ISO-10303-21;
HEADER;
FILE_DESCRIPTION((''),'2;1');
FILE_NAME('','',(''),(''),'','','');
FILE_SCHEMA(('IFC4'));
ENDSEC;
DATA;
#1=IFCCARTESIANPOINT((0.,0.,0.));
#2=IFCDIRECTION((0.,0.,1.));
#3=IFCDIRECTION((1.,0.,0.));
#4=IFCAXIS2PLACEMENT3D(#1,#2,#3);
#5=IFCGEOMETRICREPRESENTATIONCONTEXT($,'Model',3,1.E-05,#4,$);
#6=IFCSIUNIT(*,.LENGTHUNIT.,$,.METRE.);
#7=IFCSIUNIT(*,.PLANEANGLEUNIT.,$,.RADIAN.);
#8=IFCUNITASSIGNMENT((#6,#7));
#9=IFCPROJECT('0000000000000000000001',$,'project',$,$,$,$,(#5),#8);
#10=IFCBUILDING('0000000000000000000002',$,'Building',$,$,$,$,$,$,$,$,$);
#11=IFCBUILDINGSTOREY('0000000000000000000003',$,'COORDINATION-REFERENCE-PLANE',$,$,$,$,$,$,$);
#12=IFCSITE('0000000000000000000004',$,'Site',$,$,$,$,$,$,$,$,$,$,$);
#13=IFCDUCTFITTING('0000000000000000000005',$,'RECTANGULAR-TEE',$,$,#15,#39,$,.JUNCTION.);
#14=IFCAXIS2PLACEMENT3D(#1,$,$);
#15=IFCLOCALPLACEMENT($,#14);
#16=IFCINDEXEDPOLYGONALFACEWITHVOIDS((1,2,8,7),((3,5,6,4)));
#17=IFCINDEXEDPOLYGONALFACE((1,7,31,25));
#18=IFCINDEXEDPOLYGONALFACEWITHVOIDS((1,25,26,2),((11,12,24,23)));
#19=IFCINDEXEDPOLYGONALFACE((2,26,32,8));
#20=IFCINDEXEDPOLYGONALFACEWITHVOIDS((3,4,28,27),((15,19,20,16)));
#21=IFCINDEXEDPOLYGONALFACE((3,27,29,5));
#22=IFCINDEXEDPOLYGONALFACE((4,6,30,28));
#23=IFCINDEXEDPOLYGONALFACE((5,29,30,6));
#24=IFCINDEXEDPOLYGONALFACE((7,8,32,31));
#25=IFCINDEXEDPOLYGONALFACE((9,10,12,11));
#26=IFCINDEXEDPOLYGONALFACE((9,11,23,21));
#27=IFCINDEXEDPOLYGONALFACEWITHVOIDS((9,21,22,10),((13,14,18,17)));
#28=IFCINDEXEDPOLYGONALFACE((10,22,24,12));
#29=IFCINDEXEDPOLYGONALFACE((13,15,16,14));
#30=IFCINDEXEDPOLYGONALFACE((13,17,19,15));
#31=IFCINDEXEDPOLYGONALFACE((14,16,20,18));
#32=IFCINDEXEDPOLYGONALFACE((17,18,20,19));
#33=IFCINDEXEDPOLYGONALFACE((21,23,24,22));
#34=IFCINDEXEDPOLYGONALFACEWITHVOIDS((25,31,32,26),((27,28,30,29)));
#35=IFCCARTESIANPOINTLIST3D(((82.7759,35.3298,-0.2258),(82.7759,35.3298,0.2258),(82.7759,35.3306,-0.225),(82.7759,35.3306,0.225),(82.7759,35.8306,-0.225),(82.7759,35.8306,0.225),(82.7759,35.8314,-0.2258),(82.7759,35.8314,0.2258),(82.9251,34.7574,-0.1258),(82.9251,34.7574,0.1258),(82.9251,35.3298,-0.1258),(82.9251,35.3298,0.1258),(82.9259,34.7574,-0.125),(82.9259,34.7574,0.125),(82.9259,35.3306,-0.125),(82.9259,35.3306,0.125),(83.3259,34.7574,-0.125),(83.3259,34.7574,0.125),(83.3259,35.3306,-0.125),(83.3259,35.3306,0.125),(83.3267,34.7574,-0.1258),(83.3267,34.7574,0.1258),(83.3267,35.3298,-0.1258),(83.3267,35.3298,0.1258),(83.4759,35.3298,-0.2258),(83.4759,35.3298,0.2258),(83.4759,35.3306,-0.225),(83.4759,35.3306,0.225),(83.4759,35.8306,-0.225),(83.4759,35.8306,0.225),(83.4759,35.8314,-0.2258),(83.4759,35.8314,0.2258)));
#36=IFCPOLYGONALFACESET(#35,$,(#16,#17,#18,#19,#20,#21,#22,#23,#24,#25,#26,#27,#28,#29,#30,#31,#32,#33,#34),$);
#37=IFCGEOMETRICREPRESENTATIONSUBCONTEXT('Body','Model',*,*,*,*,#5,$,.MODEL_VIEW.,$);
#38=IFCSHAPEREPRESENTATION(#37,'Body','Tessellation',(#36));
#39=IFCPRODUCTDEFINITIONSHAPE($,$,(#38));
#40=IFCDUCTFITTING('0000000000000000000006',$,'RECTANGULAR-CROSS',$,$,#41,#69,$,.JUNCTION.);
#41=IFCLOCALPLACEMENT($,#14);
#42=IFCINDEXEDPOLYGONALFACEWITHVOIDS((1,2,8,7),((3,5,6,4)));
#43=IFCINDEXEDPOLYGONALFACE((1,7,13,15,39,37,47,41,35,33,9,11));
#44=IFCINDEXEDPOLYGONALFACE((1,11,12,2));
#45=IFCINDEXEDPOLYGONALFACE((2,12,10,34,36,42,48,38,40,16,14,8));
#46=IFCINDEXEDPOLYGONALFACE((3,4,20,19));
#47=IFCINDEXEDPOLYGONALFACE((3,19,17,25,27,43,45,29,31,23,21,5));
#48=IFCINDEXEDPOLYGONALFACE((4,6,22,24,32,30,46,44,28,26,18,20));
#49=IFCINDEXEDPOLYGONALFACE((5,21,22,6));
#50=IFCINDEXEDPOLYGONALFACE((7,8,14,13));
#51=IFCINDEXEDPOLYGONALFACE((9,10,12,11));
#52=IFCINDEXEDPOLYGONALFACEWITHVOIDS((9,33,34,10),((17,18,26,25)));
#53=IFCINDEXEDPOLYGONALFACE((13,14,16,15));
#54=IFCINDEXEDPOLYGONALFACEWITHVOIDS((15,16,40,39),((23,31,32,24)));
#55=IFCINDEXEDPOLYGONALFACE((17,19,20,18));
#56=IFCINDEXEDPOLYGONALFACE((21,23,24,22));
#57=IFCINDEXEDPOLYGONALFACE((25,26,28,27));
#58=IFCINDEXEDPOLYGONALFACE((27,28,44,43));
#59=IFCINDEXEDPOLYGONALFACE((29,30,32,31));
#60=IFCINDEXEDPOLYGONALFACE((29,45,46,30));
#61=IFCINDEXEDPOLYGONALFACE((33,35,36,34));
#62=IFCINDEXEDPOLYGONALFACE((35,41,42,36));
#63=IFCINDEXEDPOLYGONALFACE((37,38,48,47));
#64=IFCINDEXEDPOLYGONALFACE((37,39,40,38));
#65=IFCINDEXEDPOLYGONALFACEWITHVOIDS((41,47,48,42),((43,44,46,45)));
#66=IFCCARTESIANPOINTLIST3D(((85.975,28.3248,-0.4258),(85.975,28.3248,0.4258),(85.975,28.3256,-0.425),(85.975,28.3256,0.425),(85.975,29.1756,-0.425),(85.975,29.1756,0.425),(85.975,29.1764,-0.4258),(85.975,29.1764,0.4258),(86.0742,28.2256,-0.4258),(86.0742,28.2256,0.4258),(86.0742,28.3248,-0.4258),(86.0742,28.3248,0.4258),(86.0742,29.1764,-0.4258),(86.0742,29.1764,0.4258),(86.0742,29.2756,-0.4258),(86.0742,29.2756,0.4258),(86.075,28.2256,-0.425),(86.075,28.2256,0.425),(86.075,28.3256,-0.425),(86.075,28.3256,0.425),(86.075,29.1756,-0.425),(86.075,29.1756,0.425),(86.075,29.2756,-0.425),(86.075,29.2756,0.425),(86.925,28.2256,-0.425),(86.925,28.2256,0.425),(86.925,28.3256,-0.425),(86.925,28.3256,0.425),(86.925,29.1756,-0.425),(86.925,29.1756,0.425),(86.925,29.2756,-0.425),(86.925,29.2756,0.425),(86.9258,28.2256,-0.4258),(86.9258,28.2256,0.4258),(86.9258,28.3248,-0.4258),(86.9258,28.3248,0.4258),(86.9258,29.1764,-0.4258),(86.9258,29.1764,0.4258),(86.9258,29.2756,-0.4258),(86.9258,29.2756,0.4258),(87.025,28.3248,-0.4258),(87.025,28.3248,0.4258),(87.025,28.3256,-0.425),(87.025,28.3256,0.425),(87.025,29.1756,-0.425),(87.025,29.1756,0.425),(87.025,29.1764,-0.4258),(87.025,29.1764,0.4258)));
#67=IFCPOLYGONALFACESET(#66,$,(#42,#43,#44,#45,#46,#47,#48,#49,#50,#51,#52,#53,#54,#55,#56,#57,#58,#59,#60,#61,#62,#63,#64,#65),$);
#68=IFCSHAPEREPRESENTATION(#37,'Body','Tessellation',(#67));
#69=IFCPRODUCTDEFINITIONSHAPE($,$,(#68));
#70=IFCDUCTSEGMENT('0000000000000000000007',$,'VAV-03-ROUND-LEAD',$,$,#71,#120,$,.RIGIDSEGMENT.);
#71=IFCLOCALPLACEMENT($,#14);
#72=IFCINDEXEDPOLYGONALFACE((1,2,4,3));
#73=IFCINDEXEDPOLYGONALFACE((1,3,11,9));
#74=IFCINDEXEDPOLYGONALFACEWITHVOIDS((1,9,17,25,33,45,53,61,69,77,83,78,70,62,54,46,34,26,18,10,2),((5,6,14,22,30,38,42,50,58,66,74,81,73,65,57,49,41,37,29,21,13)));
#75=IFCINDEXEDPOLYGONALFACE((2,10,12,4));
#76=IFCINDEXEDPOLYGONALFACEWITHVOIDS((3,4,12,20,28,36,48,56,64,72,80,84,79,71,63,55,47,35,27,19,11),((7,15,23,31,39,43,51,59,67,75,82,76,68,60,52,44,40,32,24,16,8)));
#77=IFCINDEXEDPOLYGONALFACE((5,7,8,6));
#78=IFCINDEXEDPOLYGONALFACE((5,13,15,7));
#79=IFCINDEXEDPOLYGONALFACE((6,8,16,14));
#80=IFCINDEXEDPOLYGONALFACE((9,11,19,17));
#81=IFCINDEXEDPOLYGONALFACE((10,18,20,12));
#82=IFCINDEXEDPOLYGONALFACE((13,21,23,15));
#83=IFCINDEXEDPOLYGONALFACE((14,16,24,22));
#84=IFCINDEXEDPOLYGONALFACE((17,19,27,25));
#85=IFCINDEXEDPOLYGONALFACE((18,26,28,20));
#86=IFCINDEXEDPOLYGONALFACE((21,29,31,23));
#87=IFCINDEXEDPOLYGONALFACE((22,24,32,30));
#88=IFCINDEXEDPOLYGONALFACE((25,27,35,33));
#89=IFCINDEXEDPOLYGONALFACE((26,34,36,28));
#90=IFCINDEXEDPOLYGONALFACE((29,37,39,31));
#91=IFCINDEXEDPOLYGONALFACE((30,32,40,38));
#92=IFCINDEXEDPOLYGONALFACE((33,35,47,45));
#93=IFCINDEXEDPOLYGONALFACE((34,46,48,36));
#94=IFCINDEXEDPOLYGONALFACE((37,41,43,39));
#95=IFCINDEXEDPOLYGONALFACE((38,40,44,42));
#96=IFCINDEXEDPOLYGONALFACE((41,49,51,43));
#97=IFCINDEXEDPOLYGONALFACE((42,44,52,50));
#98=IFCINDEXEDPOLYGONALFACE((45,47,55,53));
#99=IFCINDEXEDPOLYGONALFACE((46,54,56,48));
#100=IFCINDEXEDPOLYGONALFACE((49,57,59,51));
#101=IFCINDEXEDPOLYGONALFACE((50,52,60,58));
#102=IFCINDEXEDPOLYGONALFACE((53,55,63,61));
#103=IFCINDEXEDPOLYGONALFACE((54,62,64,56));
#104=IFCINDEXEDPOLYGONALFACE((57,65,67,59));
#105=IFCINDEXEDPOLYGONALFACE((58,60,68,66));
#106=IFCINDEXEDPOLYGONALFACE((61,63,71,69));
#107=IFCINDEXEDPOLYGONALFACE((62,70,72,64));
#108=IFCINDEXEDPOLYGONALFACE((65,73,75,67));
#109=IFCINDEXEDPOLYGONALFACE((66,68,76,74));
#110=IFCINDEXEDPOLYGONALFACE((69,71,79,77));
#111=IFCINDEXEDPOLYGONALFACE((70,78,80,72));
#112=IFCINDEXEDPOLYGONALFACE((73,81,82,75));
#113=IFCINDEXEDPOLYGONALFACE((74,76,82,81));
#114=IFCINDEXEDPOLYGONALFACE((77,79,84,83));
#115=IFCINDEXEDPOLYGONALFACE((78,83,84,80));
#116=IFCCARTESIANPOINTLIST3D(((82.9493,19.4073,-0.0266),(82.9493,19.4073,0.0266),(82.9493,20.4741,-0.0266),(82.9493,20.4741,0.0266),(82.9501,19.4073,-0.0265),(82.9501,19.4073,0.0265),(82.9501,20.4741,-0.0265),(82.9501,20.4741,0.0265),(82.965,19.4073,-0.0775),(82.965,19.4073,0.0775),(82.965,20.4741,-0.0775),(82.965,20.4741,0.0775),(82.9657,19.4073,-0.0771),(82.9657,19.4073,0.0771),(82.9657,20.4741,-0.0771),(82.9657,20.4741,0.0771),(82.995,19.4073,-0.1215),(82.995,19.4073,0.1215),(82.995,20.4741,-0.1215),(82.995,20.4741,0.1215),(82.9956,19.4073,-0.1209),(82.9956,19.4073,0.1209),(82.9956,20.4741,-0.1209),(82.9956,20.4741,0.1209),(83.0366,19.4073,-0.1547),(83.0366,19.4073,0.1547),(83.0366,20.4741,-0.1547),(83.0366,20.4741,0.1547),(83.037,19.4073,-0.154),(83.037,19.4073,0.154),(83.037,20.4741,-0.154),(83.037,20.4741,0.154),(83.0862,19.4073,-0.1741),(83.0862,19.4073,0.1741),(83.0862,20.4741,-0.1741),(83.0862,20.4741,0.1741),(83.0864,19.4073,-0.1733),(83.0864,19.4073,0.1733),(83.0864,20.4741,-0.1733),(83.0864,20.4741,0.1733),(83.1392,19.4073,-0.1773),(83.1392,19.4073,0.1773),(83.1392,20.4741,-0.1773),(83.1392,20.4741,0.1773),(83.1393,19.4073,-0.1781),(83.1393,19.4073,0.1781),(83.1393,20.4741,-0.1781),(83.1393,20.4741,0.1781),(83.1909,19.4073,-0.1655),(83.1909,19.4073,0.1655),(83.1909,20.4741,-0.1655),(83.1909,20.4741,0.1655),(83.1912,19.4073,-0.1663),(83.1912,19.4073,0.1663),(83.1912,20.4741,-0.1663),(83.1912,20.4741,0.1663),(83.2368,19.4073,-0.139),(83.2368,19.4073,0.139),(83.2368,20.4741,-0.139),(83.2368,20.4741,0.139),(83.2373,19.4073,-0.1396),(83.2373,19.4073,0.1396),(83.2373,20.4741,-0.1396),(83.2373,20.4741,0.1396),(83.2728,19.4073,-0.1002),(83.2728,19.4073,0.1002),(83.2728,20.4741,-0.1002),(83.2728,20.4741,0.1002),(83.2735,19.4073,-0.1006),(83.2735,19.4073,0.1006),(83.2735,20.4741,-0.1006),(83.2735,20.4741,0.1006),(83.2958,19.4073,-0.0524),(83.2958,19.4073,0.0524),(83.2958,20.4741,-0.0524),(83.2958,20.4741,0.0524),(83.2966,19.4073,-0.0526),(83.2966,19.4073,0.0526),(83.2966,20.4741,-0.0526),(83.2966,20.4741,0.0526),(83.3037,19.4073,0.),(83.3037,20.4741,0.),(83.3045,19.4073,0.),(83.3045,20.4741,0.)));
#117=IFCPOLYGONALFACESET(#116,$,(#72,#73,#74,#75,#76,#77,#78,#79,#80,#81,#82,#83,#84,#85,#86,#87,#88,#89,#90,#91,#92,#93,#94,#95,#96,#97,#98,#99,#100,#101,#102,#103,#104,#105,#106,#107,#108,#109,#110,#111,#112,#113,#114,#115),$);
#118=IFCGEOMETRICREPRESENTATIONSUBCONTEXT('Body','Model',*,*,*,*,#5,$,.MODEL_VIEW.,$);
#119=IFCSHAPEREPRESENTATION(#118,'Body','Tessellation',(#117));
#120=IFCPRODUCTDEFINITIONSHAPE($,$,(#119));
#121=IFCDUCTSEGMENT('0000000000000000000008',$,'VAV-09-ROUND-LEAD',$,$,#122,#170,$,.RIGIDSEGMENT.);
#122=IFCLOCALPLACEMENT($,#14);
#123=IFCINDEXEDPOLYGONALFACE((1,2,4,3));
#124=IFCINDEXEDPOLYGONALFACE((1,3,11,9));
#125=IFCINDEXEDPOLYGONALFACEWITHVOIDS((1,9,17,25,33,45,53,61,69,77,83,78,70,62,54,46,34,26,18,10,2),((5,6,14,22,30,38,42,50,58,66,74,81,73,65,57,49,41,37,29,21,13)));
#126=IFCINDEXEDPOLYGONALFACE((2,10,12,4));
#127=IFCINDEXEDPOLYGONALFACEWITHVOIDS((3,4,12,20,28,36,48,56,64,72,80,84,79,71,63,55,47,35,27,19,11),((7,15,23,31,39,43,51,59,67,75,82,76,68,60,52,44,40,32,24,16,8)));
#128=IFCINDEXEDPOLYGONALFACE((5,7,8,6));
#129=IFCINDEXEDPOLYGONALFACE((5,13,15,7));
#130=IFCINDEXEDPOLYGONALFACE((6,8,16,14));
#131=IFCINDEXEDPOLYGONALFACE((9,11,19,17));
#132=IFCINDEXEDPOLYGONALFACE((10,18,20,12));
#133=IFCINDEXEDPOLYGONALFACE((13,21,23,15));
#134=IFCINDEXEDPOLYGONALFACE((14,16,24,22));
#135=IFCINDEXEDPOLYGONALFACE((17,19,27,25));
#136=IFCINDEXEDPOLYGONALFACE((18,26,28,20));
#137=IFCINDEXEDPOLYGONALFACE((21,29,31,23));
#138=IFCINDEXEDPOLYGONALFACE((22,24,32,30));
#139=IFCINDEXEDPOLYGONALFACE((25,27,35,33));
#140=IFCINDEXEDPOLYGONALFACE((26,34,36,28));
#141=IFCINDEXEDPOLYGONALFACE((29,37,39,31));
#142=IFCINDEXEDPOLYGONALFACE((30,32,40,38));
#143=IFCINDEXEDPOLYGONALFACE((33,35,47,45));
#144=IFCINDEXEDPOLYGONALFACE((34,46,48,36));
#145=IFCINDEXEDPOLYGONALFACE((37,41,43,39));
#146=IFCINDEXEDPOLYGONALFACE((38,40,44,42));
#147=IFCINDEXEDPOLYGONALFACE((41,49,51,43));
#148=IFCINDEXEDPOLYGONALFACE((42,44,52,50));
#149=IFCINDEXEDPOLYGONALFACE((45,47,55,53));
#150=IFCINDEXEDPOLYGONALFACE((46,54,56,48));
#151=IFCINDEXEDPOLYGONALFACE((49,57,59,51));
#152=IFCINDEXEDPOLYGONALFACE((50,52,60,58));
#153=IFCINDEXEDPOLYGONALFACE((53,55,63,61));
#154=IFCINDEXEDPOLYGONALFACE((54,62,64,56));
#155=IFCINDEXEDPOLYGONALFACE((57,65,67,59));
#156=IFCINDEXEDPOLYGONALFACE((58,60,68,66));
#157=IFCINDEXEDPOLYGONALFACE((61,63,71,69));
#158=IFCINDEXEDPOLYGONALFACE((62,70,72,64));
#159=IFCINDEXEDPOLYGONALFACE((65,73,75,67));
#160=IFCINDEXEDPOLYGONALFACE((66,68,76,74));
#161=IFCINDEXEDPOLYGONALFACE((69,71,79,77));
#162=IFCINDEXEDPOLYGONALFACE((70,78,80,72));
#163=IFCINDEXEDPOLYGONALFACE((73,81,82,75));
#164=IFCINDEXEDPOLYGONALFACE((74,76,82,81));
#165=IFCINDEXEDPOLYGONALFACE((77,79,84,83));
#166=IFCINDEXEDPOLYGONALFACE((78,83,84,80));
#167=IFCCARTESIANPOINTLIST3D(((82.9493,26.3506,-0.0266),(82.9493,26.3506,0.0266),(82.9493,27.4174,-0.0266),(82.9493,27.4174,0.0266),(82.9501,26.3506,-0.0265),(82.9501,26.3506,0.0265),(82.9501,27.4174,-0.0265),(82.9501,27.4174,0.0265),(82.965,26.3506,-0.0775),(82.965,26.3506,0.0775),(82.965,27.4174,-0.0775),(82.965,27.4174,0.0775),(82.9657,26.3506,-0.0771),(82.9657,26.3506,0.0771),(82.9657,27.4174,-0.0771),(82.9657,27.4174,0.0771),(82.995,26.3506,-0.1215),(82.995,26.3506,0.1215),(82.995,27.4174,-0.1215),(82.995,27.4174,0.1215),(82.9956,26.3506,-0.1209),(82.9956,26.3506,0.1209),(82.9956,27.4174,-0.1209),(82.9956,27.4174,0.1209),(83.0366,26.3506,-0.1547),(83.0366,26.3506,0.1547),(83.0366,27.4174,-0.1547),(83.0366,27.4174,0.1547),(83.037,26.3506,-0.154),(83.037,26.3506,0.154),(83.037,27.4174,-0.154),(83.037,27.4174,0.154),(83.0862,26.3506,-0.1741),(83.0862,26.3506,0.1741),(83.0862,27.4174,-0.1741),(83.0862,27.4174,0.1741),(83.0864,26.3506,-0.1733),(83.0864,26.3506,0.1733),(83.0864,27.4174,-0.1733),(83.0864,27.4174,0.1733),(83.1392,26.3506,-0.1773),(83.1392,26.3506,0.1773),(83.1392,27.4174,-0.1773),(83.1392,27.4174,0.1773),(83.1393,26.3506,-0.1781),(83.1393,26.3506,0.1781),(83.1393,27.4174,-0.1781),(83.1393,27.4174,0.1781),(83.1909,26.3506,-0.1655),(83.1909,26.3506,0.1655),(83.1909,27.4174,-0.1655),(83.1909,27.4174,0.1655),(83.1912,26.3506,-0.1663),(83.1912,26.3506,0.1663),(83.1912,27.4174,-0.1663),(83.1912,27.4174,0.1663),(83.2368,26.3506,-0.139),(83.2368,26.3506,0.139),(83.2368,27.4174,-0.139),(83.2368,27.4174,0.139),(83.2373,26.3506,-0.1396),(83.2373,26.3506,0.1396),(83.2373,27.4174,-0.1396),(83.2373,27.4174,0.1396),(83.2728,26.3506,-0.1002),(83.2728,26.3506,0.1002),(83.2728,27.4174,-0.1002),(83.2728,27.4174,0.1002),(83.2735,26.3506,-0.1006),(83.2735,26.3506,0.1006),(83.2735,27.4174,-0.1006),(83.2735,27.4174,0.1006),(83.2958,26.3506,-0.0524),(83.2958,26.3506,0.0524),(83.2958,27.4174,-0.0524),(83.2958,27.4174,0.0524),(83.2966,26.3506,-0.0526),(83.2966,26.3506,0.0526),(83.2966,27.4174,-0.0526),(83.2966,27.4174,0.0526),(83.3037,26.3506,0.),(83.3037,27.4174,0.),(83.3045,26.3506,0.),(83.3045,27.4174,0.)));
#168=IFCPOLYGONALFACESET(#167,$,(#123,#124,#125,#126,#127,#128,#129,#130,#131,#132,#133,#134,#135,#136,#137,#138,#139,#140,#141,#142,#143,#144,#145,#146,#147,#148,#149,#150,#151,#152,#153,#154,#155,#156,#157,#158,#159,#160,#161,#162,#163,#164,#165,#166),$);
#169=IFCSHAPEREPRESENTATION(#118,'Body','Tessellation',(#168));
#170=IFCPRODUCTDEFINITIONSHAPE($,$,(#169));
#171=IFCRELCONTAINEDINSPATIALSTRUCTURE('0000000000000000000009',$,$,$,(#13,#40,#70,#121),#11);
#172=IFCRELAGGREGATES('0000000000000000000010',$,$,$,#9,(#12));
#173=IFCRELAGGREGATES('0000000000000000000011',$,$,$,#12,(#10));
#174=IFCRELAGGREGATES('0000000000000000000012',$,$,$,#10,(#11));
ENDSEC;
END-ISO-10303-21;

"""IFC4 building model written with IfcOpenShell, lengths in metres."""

from ifc_helpers import new_model, si_unit, frame, origin, origin_with_axes, place, context, subcontext, project, spatial, rectangle, hollow_circle, extrude, boolean, element, save


model = new_model("IFC4")

# Units and contexts
model_context = context("Model", 3, precision=1e-05, world=origin_with_axes())
body_context_1 = subcontext(model_context, "Body", "Model", "MODEL_VIEW")
body_context_2 = subcontext(model_context, "Body", "Model", "MODEL_VIEW")
ifc_project = project(units=[si_unit("LENGTHUNIT", "METRE"), si_unit("PLANEANGLEUNIT", "RADIAN")], contexts=[model_context])

# Site, building, storey
site = spatial("IfcSite", under=ifc_project, Name="Site")
building = spatial("IfcBuilding", under=site, Name="Building")
storey = spatial("IfcBuildingStorey", under=building, Name="COORDINATION-REFERENCE-PLANE")

# Duct fittings
duct_fitting_1_placement = place(None, frame((83.1259, 35.5806, 0.0), z_axis=(-1.0, 0.0, 0.0), x_axis=(0.0, -1.0, 0.0)))
solid_1 = boolean("UNION", extrude(rectangle(XDim=0.5, YDim=0.45), frame((0.0, 0.0, -0.35), z_axis=(0.0, 0.0, 1.0), x_axis=(1.0, 0.0, 0.0)), (0.0, 0.0, 1.0), 0.7), extrude(rectangle(XDim=0.4, YDim=0.25), frame((0.0, 0.0, 0.0), z_axis=(1.0, 0.0, 0.0), x_axis=(0.0, 0.0, -1.0)), (0.0, 0.0, 1.0), 0.8232))
element("IfcDuctFitting", 1, at=duct_fitting_1_placement, inside=storey, Name="RECTANGULAR-TEE", PredefinedType="JUNCTION", context=body_context_1, shape_type="CSG", body=[
    boolean("DIFFERENCE", boolean("UNION", extrude(rectangle(XDim=0.5016, YDim=0.4516), frame((0.0, 0.0, -0.35), z_axis=(0.0, 0.0, 1.0), x_axis=(1.0, 0.0, 0.0)), (0.0, 0.0, 1.0), 0.7), extrude(rectangle(XDim=0.4016, YDim=0.2516), frame((0.0, 0.0, 0.0), z_axis=(1.0, 0.0, 0.0), x_axis=(0.0, 0.0, -1.0)), (0.0, 0.0, 1.0), 0.8232)), solid_1),
])
duct_fitting_2_placement = place(None, frame((86.5, 28.7506, 0.0), z_axis=(0.0, -1.0, 0.0), x_axis=(1.0, 0.0, 0.0)))
solid_2 = boolean("UNION", extrude(rectangle(XDim=0.85, YDim=0.85), frame((0.0, 0.0, -0.525), z_axis=(0.0, 0.0, 1.0), x_axis=(1.0, 0.0, 0.0)), (0.0, 0.0, 1.0), 1.05), extrude(rectangle(XDim=0.85, YDim=0.85), frame((-0.525, 0.0, 0.0), z_axis=(1.0, 0.0, 0.0), x_axis=(0.0, 0.0, -1.0)), (0.0, 0.0, 1.0), 1.05))
element("IfcDuctFitting", 2, at=duct_fitting_2_placement, inside=storey, Name="RECTANGULAR-CROSS", PredefinedType="JUNCTION", context=body_context_1, shape_type="CSG", body=[
    boolean("DIFFERENCE", boolean("UNION", extrude(rectangle(XDim=0.8516, YDim=0.8516), frame((0.0, 0.0, -0.525), z_axis=(0.0, 0.0, 1.0), x_axis=(1.0, 0.0, 0.0)), (0.0, 0.0, 1.0), 1.05), extrude(rectangle(XDim=0.8516, YDim=0.8516), frame((-0.525, 0.0, 0.0), z_axis=(1.0, 0.0, 0.0), x_axis=(0.0, 0.0, -1.0)), (0.0, 0.0, 1.0), 1.05)), solid_2),
])

# Duct segments
for number, where, z_axis, x_axis, name in (
    (3, (83.1259, 20.4741, 0.0), (0.0, -1.0, 0.0), (1.0, 0.0, 0.0), "VAV-03-ROUND-LEAD"),
    (4, (83.1259, 27.4174, 0.0), (0.0, -1.0, 0.0), (1.0, 0.0, 0.0), "VAV-09-ROUND-LEAD"),
):
    element("IfcDuctSegment", number, at=place(None, frame(where, z_axis=z_axis, x_axis=x_axis)), inside=storey, Name=name, PredefinedType="RIGIDSEGMENT", context=body_context_2, shape_type="SweptSolid", body=[
        extrude(hollow_circle(Radius=0.1786, WallThickness=0.0008), origin(), (0.0, 0.0, 1.0), 1.0668),
    ])

save(model, "model.ifc")
